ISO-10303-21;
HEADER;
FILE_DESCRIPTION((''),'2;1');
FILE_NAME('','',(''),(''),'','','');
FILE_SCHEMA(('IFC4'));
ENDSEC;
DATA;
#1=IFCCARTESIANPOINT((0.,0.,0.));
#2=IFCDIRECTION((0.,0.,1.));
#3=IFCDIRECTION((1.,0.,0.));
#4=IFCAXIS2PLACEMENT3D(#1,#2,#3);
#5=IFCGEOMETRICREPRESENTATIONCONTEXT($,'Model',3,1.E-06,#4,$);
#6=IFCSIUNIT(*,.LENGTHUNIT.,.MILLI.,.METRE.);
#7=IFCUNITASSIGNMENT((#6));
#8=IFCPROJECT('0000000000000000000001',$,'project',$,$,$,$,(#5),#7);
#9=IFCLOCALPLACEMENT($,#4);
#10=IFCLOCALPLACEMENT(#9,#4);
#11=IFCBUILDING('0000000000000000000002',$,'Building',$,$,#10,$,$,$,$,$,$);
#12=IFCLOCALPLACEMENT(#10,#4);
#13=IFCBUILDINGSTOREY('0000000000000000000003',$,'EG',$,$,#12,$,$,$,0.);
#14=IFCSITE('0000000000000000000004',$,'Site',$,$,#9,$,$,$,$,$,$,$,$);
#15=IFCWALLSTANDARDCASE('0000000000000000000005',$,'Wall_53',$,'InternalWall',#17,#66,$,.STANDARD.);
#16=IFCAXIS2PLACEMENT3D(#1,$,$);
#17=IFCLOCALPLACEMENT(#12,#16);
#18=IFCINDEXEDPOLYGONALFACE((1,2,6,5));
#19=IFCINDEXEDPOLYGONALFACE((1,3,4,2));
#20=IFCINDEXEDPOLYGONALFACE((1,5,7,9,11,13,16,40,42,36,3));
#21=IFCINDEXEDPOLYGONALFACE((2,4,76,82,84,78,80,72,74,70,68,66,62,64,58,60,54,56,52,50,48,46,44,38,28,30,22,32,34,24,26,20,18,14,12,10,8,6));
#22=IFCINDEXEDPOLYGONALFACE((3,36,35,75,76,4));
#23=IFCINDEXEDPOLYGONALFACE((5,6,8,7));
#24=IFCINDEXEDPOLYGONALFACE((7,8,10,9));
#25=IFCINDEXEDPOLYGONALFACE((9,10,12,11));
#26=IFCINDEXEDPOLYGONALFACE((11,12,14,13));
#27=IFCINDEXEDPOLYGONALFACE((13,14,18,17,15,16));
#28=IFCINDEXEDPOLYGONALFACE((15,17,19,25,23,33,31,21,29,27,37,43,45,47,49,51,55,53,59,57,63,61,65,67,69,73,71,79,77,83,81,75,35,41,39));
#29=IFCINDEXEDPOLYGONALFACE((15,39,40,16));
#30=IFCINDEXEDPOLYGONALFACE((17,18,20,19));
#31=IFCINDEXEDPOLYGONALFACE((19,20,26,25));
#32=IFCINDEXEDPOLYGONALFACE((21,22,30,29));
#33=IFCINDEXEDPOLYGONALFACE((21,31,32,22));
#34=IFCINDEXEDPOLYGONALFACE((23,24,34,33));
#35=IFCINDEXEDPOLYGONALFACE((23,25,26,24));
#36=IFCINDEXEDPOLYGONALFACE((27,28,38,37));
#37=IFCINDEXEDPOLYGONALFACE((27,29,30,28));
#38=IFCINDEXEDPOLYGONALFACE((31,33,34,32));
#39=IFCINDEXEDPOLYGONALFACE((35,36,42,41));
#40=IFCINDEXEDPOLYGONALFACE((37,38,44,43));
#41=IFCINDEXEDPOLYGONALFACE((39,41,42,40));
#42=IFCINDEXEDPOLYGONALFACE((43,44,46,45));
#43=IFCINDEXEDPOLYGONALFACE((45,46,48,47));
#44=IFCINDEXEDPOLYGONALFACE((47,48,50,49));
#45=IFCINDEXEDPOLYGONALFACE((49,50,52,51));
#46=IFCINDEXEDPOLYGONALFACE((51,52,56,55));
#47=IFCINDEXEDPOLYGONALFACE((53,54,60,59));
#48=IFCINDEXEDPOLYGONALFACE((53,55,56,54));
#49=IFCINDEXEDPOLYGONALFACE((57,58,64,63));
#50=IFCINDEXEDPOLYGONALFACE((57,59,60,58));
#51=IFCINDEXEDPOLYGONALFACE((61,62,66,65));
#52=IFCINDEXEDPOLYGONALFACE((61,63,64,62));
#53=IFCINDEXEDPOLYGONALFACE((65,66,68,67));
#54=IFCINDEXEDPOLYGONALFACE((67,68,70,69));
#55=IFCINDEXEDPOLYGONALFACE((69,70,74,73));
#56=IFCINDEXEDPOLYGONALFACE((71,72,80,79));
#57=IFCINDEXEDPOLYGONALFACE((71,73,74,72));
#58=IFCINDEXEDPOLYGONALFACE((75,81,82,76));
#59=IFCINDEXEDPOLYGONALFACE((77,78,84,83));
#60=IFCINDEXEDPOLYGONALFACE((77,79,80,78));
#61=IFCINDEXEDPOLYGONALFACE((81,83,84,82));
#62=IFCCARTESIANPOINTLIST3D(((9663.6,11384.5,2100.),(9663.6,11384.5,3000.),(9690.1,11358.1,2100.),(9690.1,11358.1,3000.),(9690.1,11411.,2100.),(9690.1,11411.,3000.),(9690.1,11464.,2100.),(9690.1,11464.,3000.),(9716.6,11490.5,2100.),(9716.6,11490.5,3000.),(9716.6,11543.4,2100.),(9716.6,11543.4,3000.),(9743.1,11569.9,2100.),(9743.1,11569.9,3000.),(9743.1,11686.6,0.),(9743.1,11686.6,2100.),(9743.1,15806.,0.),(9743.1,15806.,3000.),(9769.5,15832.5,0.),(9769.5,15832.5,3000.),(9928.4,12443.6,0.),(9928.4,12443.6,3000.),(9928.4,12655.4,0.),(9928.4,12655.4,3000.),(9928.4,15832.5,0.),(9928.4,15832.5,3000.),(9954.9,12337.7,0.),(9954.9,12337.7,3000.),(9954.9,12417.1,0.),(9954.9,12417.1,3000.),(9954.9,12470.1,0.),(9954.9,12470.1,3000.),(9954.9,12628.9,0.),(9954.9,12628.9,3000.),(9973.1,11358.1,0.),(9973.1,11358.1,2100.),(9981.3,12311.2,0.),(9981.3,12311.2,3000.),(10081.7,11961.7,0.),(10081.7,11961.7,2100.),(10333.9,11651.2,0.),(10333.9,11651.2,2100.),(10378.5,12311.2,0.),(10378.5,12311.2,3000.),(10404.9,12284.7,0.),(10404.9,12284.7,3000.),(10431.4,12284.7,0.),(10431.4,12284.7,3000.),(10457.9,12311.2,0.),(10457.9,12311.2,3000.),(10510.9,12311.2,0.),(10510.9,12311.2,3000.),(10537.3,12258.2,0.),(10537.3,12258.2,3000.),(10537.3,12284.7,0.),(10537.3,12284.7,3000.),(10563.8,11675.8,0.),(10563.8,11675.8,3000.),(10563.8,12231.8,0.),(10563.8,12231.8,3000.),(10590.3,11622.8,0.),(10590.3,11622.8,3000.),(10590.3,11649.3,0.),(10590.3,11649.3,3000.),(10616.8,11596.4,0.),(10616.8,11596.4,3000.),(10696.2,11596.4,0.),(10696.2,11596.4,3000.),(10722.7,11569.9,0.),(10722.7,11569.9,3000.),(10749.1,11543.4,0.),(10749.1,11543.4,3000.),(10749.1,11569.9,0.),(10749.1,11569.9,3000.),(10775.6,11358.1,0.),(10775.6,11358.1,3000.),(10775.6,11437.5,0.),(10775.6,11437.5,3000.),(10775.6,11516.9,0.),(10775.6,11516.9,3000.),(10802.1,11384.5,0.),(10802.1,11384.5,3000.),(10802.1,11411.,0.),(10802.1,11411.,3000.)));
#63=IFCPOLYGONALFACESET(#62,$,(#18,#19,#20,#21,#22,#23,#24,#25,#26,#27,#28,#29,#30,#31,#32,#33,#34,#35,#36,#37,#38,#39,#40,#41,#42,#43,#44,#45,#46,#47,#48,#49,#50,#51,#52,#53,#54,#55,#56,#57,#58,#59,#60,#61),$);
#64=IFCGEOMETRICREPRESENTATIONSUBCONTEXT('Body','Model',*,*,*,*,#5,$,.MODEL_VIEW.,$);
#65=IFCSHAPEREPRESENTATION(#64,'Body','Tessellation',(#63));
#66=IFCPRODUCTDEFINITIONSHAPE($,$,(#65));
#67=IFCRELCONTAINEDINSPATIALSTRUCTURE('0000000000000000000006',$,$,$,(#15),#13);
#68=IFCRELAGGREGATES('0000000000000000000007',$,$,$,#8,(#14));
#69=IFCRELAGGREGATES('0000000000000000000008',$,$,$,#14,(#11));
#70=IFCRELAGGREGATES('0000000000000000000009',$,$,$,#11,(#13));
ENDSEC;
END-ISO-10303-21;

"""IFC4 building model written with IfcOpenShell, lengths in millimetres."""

from ifc_helpers import new_model, si_unit, frame, origin_with_axes, place, context, subcontext, project, spatial, polyline, rectangle, outline, extrude, element, save


model = new_model("IFC4")

# Units and contexts
model_context = context("Model", 3, precision=1e-06, world=origin_with_axes())
body_context = subcontext(model_context, "Body", "Model", "MODEL_VIEW")
ifc_project = project(units=[si_unit("LENGTHUNIT", "METRE", prefix="MILLI")], contexts=[model_context])

# Site, building, storey
site_placement = place(None, origin_with_axes())
site = spatial("IfcSite", under=ifc_project, at=site_placement, Name="Site")
building_placement = place(site_placement, origin_with_axes())
building = spatial("IfcBuilding", under=site, at=building_placement, Name="Building")
storey_placement = place(building_placement, origin_with_axes())
storey = spatial("IfcBuildingStorey", under=building, at=storey_placement, Name="EG", Elevation=0.0)

# Wall, opening
wall_1_placement = place(storey_placement, origin_with_axes())
wall_1 = element("IfcWallStandardCase", 1, at=wall_1_placement, inside=storey, Name="Wall_53", ObjectType="InternalWall", PredefinedType="STANDARD", context=body_context, shape_type="SweptSolid", body=[
    extrude(outline(polyline([(9690.1, 11358.1, 0.0), (9663.6, 11384.5, 0.0), (9690.1, 11411.0, 0.0), (9690.1, 11464.0, 0.0), (9716.6, 11490.5, 0.0), (9716.6, 11543.4, 0.0), (9743.1, 11569.9, 0.0), (9743.1, 15806.0, 0.0), (9769.5, 15832.5, 0.0), (9928.4, 15832.5, 0.0), (9928.4, 12655.4, 0.0), (9954.9, 12628.9, 0.0), (9954.9, 12470.1, 0.0), (9928.4, 12443.6, 0.0), (9954.9, 12417.1, 0.0), (9954.9, 12337.7, 0.0), (9981.3, 12311.2, 0.0), (10378.5, 12311.2, 0.0), (10404.9, 12284.7, 0.0), (10431.4, 12284.7, 0.0), (10457.9, 12311.2, 0.0), (10510.9, 12311.2, 0.0), (10537.3, 12284.7, 0.0), (10537.3, 12258.2, 0.0), (10563.8, 12231.8, 0.0), (10563.8, 11675.8, 0.0), (10590.3, 11649.3, 0.0), (10590.3, 11622.8, 0.0), (10616.8, 11596.4, 0.0), (10696.2, 11596.4, 0.0), (10722.7, 11569.9, 0.0), (10749.1, 11569.9, 0.0), (10749.1, 11543.4, 0.0), (10775.6, 11516.9, 0.0), (10775.6, 11437.5, 0.0), (10802.1, 11411.0, 0.0), (10802.1, 11384.5, 0.0), (10775.6, 11358.1, 0.0), (9690.1, 11358.1, 0.0)])), origin_with_axes(), (0.0, 0.0, 1.0), 3000.0),
])
opening_1_placement = place(wall_1_placement, origin_with_axes())
element("IfcOpeningElement", 2, at=opening_1_placement, inside=storey, cuts=wall_1, context=body_context, shape_type="SweptSolid", body=[
    extrude(rectangle(XDim=1342.1, YDim=400.0), frame((9687.0, 11383.3, 0.0), z_axis=(0.0, 0.0, 1.0), x_axis=(-0.776114, -0.630593, 0.0)), (0.0, 0.0, 1.0), 2100.0),
])

save(model, "model.ifc")
